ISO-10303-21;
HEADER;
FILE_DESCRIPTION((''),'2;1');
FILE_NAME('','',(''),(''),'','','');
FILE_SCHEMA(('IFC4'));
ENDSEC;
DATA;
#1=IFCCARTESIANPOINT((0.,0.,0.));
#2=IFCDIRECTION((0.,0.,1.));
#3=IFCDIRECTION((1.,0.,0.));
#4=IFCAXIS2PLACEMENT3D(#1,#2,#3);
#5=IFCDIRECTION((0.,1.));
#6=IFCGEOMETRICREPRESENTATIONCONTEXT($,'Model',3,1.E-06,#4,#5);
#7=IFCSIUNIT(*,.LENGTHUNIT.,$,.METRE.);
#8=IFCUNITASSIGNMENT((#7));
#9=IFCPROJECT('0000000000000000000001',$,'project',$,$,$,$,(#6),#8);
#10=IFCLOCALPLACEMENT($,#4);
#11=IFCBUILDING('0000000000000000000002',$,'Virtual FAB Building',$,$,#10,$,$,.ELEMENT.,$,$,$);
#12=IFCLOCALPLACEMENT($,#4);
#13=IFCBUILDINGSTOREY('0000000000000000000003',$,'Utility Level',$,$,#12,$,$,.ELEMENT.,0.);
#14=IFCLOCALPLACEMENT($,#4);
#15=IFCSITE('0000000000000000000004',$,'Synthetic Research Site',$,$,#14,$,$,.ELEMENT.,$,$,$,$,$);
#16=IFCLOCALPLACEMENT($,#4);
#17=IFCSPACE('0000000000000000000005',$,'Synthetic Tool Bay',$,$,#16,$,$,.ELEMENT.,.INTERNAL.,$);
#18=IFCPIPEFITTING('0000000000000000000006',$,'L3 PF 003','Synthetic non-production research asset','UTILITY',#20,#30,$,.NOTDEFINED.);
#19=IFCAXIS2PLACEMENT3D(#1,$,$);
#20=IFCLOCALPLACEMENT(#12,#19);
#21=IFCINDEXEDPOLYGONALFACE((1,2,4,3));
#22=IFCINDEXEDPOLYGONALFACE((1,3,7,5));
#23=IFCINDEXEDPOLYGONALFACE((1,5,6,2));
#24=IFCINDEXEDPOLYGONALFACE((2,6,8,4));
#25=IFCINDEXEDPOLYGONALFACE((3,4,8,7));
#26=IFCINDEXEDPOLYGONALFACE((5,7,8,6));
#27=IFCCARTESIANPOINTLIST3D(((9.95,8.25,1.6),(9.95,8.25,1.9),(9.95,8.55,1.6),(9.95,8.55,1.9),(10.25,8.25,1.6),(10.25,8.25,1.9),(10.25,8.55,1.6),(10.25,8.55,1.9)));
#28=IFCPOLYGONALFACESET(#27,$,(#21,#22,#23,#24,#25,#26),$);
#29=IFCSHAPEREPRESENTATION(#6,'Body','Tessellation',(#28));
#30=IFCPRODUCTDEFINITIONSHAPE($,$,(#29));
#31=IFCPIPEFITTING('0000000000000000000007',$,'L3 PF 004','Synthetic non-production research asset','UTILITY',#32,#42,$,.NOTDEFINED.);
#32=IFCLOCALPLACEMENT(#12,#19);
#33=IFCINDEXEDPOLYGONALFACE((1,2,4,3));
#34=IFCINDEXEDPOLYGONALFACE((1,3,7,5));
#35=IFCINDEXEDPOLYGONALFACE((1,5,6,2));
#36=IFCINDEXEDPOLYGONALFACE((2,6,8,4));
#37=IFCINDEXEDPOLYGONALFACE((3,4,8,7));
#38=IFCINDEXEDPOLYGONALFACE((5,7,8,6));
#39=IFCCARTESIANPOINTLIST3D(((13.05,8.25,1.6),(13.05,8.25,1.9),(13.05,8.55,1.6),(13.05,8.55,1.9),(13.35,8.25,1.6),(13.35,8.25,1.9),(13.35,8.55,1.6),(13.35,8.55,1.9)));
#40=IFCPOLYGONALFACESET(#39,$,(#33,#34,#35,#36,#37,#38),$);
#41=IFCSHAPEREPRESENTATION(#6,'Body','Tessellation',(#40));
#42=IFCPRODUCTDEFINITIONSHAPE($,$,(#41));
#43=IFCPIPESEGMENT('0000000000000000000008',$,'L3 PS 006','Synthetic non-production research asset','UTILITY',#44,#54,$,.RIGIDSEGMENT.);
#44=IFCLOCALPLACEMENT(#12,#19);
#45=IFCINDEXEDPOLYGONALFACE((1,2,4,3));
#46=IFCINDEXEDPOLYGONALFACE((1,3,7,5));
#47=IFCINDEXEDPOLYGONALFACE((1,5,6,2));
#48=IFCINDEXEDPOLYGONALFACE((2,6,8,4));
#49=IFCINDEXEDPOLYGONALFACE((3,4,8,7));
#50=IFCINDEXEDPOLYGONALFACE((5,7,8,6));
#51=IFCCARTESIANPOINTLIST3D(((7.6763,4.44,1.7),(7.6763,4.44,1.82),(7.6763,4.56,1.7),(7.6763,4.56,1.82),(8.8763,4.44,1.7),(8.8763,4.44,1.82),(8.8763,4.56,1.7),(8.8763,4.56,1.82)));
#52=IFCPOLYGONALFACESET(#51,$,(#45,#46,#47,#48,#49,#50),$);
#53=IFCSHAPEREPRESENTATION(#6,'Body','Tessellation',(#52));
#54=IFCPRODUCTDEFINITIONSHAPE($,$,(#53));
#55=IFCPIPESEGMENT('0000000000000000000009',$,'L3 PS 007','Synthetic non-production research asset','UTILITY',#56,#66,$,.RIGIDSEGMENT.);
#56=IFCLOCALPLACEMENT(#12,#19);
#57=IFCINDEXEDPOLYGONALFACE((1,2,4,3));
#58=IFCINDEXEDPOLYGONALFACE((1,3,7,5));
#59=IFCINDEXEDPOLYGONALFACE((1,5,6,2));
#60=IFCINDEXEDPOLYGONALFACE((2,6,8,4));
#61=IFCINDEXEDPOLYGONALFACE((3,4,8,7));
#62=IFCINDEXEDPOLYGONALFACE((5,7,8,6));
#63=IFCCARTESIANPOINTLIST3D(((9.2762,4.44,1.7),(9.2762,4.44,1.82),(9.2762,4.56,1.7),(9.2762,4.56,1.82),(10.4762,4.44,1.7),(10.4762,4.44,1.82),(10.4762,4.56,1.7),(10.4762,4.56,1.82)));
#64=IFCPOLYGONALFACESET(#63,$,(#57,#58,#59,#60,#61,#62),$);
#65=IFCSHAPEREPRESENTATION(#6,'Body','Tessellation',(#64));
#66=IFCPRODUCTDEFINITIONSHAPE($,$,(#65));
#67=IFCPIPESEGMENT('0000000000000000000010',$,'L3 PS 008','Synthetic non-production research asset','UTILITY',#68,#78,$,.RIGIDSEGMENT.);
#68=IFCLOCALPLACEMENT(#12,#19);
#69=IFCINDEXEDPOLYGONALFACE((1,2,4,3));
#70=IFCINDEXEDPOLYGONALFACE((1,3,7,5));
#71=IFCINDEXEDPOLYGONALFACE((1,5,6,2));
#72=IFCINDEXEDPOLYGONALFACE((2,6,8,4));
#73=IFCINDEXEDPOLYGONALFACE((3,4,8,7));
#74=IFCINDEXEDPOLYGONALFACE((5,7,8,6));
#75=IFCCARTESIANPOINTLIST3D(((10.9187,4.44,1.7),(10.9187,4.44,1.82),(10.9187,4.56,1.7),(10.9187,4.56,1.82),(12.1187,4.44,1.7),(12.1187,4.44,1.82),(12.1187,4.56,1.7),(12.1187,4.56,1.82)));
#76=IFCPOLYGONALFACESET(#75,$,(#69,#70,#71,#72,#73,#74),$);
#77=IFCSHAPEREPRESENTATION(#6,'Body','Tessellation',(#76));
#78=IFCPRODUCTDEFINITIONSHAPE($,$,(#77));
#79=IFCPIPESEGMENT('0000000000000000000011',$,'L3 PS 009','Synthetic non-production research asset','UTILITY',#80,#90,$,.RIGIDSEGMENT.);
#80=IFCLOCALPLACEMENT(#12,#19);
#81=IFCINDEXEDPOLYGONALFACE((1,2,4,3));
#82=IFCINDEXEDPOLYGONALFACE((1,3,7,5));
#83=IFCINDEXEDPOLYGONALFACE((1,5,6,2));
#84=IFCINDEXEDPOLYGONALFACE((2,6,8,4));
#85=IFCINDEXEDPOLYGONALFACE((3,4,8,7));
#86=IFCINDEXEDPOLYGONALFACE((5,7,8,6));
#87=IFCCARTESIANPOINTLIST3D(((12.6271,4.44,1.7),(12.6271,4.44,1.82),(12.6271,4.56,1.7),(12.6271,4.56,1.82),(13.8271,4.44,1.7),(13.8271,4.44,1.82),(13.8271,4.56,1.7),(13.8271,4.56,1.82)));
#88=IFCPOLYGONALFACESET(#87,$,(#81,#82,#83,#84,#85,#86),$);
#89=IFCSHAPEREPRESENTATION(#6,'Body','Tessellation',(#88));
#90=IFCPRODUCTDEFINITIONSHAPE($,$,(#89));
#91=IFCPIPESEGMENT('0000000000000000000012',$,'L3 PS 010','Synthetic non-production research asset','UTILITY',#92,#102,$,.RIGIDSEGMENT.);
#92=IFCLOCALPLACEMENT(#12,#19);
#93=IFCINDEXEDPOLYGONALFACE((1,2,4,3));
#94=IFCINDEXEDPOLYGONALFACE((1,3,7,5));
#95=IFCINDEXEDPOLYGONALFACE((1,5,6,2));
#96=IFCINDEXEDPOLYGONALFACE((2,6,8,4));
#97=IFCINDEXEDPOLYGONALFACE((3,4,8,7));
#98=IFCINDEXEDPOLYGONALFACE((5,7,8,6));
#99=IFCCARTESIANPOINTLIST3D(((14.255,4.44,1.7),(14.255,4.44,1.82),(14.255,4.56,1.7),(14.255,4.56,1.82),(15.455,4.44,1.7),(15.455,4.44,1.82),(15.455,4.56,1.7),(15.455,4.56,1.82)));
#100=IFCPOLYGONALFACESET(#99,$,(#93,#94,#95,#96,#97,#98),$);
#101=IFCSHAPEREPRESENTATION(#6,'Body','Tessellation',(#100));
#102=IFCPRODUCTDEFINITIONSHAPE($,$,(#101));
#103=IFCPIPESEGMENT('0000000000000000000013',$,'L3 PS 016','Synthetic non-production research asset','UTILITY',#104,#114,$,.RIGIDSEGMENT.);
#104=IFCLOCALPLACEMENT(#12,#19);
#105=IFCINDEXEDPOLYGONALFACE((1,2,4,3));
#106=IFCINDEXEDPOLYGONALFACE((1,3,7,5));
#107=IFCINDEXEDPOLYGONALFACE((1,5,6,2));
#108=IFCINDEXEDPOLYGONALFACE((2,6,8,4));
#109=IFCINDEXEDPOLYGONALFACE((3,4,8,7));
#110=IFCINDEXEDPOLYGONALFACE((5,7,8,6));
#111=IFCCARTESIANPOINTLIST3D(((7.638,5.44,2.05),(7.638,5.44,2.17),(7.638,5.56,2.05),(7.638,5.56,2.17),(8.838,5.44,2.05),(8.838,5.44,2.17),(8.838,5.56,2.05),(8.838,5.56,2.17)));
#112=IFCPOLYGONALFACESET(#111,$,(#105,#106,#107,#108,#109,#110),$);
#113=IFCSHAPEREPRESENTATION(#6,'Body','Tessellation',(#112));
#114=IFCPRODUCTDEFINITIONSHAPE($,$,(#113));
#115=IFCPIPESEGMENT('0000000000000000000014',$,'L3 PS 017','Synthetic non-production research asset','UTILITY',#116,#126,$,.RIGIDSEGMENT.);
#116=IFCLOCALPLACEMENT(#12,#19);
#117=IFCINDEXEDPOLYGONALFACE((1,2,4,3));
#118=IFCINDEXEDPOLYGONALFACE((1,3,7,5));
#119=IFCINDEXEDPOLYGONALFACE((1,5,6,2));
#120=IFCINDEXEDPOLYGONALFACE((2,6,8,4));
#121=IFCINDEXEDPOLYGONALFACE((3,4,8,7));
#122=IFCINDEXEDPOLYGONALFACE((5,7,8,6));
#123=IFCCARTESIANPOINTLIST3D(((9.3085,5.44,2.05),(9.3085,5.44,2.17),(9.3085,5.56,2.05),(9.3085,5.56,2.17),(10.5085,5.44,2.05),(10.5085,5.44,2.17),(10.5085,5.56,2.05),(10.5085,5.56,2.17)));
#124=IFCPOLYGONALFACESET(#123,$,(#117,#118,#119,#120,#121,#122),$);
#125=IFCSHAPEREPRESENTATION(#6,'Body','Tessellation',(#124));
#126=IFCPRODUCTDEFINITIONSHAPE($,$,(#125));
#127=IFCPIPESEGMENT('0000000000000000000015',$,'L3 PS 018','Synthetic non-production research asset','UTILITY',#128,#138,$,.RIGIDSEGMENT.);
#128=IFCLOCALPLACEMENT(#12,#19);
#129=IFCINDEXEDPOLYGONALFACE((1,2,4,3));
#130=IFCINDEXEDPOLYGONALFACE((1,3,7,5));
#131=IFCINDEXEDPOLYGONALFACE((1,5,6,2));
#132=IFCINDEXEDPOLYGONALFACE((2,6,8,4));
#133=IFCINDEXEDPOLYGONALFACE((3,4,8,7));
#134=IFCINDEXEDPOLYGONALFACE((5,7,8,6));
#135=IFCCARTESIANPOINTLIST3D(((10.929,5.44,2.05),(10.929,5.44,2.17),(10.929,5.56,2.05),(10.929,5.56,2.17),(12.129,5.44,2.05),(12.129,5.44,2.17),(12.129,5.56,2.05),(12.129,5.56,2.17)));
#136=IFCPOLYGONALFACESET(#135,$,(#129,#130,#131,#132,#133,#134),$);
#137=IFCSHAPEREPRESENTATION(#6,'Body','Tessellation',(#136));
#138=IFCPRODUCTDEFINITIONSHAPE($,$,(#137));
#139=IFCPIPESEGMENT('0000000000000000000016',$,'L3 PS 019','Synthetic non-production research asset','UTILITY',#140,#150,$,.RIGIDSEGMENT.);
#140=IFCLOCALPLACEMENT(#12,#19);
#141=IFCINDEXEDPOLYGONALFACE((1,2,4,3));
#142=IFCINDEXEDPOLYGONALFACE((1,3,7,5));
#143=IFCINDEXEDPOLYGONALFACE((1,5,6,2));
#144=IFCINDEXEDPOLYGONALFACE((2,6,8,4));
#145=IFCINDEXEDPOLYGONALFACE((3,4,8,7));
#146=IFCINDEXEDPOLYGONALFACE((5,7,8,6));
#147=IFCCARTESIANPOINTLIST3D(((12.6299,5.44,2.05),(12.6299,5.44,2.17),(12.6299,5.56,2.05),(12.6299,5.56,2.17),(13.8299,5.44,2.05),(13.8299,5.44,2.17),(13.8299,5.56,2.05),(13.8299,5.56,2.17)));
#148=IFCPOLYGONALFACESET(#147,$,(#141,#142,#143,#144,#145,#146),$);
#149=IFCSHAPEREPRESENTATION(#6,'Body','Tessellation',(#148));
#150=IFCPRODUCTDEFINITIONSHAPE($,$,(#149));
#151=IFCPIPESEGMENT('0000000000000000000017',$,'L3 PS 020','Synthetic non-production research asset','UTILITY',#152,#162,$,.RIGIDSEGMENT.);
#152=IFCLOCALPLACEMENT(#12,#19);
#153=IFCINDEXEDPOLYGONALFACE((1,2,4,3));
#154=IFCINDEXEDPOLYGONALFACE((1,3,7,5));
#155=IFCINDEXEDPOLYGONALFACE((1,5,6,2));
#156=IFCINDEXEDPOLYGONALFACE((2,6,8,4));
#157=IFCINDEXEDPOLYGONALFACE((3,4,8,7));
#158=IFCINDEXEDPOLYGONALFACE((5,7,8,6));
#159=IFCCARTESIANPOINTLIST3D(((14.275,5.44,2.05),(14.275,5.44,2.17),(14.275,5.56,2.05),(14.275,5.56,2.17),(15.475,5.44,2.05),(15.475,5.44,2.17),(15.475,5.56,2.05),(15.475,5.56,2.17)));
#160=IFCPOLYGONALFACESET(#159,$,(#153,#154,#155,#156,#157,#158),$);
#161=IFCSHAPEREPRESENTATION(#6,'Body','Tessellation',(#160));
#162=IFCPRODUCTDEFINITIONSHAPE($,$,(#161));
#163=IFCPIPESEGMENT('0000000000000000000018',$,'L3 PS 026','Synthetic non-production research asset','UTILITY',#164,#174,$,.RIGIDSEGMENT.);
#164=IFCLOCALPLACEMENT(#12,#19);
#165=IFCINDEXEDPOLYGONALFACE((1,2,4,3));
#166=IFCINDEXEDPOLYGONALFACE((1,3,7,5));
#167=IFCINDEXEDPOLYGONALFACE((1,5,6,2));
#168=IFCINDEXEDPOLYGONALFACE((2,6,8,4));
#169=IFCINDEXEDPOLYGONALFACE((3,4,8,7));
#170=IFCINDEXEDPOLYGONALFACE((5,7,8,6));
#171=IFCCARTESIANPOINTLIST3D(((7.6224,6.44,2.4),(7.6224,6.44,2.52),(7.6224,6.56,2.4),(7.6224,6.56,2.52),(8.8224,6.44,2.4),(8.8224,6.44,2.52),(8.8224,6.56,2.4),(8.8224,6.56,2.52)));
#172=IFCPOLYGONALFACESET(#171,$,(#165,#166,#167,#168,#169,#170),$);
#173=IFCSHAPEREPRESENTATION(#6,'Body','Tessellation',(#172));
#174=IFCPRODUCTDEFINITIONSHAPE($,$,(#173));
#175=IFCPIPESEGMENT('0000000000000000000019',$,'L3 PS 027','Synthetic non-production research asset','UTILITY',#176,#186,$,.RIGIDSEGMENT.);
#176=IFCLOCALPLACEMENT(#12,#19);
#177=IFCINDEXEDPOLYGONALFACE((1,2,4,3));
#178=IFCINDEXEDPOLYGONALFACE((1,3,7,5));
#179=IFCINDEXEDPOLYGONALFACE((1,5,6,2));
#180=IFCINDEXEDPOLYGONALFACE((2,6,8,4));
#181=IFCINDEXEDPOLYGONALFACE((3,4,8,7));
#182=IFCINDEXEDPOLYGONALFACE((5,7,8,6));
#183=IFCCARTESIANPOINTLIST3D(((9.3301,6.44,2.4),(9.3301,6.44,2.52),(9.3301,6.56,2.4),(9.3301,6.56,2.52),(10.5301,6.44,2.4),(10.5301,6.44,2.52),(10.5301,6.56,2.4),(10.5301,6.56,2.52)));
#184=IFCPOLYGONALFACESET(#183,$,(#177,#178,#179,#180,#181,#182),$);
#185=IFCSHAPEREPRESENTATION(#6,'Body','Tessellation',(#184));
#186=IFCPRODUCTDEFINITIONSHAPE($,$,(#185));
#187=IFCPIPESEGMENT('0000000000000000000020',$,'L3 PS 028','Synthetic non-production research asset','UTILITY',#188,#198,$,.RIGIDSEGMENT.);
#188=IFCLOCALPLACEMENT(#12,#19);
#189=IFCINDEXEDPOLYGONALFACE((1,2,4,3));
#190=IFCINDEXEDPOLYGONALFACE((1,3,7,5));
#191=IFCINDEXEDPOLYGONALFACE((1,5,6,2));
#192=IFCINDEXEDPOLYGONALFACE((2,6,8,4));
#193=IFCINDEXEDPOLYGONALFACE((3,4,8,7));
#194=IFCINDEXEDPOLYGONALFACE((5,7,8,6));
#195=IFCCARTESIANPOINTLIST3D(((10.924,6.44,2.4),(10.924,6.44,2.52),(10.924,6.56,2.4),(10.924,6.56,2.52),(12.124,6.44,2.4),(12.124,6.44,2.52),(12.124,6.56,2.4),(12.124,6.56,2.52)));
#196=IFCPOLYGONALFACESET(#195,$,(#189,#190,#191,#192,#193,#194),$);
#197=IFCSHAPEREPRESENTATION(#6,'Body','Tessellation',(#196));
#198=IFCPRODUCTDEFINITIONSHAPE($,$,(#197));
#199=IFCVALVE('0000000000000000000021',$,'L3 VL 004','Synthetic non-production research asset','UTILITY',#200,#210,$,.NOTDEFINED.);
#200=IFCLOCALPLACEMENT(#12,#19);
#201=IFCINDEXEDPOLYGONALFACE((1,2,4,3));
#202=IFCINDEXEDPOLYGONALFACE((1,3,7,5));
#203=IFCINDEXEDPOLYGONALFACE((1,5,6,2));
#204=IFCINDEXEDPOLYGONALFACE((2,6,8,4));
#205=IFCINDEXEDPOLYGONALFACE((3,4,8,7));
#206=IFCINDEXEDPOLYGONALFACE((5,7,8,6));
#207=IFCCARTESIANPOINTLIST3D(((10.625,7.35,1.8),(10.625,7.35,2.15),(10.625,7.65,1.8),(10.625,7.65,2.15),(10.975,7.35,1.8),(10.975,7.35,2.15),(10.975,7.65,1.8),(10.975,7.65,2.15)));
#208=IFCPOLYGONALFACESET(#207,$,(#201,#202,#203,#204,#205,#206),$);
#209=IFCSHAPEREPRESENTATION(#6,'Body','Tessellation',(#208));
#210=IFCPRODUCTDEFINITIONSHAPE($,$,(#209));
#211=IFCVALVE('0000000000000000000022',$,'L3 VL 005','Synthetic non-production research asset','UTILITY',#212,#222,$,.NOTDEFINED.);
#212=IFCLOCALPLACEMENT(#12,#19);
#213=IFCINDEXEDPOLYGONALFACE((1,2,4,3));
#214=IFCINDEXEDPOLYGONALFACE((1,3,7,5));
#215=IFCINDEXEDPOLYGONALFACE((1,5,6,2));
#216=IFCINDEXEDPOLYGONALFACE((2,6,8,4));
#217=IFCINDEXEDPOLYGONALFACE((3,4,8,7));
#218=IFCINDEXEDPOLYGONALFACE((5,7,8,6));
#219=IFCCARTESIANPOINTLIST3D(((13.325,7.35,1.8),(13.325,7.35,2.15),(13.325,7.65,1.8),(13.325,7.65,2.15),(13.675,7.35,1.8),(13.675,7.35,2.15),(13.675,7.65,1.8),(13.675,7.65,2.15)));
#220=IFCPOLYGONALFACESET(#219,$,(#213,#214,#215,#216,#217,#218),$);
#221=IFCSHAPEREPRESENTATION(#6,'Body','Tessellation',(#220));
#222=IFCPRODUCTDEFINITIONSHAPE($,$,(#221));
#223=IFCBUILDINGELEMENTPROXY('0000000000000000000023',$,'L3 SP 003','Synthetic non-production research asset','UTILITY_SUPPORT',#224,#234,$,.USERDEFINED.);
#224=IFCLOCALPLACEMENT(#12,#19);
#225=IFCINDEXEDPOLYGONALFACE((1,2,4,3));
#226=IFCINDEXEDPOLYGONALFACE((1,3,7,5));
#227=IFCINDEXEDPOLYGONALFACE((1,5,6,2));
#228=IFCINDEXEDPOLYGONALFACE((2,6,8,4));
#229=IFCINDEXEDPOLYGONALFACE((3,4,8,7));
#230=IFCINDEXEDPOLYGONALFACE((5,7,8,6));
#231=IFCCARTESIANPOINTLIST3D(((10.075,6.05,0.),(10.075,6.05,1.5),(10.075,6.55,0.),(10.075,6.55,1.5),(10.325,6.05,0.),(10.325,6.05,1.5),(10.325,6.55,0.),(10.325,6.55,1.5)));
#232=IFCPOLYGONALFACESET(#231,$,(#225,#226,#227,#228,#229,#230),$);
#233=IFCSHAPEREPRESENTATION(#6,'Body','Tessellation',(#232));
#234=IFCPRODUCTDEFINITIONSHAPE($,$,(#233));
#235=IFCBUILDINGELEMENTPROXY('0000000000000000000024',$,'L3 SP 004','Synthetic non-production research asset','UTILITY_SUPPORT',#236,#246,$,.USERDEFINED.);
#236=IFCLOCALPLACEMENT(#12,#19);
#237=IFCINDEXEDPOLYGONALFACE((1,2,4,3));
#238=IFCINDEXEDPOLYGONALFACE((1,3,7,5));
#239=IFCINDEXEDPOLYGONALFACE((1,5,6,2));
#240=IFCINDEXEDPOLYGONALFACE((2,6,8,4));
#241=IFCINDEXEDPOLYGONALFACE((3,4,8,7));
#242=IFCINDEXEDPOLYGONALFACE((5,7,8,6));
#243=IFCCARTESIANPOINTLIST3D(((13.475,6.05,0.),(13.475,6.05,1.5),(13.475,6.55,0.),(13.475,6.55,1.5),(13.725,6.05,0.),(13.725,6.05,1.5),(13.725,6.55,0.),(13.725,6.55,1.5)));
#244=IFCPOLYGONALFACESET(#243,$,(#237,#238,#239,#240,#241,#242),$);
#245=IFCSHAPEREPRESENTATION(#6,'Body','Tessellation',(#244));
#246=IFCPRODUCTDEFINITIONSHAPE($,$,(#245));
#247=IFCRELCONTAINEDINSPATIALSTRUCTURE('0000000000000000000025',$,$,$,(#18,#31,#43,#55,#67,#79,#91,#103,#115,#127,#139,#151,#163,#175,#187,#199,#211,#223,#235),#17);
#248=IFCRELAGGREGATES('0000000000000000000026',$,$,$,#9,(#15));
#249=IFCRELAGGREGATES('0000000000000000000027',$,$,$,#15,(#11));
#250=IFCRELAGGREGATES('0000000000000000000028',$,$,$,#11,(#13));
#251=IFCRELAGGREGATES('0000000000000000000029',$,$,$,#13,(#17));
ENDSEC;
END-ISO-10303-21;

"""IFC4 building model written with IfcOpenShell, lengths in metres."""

from ifc_helpers import new_model, si_unit, direction, frame, origin_with_axes, origin_2d_with_axis, place, context, project, spatial, rectangle, extrude, element, save


model = new_model("IFC4")

# Units and contexts
model_context = context("Model", 3, precision=1e-06, world=origin_with_axes(), true_north=direction((0.0, 1.0)))
ifc_project = project(units=[si_unit("LENGTHUNIT", "METRE")], contexts=[model_context])

# Site, building, storey, space
site_placement = place(None, origin_with_axes())
site = spatial("IfcSite", under=ifc_project, at=site_placement, Name="Synthetic Research Site", CompositionType="ELEMENT")
building_placement = place(None, origin_with_axes())
building = spatial("IfcBuilding", under=site, at=building_placement, Name="Virtual FAB Building", CompositionType="ELEMENT")
storey_placement = place(None, origin_with_axes())
storey = spatial("IfcBuildingStorey", under=building, at=storey_placement, Name="Utility Level", CompositionType="ELEMENT", Elevation=0.0)
space_placement = place(None, origin_with_axes())
space = spatial("IfcSpace", under=storey, at=space_placement, Name="Synthetic Tool Bay", CompositionType="ELEMENT", PredefinedType="INTERNAL")

# Pipe fittings
for number, where, z_axis, x_axis, name in (
    (1, (10.1, 8.4, 1.6), (0.0, 0.0, 1.0), (1.0, 0.0, 0.0), "L3 PF 003"),
    (2, (13.2, 8.4, 1.6), (0.0, 0.0, 1.0), (1.0, 0.0, 0.0), "L3 PF 004"),
):
    element("IfcPipeFitting", number, at=place(None, frame(where, z_axis=z_axis, x_axis=x_axis)), inside=space, Name=name, Description="Synthetic non-production research asset", ObjectType="UTILITY", PredefinedType="NOTDEFINED", context=model_context, shape_type="SweptSolid", body=[
        extrude(rectangle(XDim=0.3, YDim=0.3, at=origin_2d_with_axis()), origin_with_axes(), (0.0, 0.0, 1.0), 0.3),
    ])

# Pipe segments
for number, where, z_axis, x_axis, name in (
    (3, (8.2763, 4.5, 1.7), (0.0, 0.0, 1.0), (1.0, 0.0, 0.0), "L3 PS 006"),
    (4, (9.8762, 4.5, 1.7), (0.0, 0.0, 1.0), (1.0, 0.0, 0.0), "L3 PS 007"),
    (5, (11.5187, 4.5, 1.7), (0.0, 0.0, 1.0), (1.0, 0.0, 0.0), "L3 PS 008"),
    (6, (13.2271, 4.5, 1.7), (0.0, 0.0, 1.0), (1.0, 0.0, 0.0), "L3 PS 009"),
    (7, (14.855, 4.5, 1.7), (0.0, 0.0, 1.0), (1.0, 0.0, 0.0), "L3 PS 010"),
    (8, (8.238, 5.5, 2.05), (0.0, 0.0, 1.0), (1.0, 0.0, 0.0), "L3 PS 016"),
    (9, (9.9085, 5.5, 2.05), (0.0, 0.0, 1.0), (1.0, 0.0, 0.0), "L3 PS 017"),
    (10, (11.529, 5.5, 2.05), (0.0, 0.0, 1.0), (1.0, 0.0, 0.0), "L3 PS 018"),
    (11, (13.2299, 5.5, 2.05), (0.0, 0.0, 1.0), (1.0, 0.0, 0.0), "L3 PS 019"),
    (12, (14.875, 5.5, 2.05), (0.0, 0.0, 1.0), (1.0, 0.0, 0.0), "L3 PS 020"),
    (13, (8.2224, 6.5, 2.4), (0.0, 0.0, 1.0), (1.0, 0.0, 0.0), "L3 PS 026"),
    (14, (9.9301, 6.5, 2.4), (0.0, 0.0, 1.0), (1.0, 0.0, 0.0), "L3 PS 027"),
    (15, (11.524, 6.5, 2.4), (0.0, 0.0, 1.0), (1.0, 0.0, 0.0), "L3 PS 028"),
):
    element("IfcPipeSegment", number, at=place(None, frame(where, z_axis=z_axis, x_axis=x_axis)), inside=space, Name=name, Description="Synthetic non-production research asset", ObjectType="UTILITY", PredefinedType="RIGIDSEGMENT", context=model_context, shape_type="SweptSolid", body=[
        extrude(rectangle(XDim=1.2, YDim=0.12, at=origin_2d_with_axis()), origin_with_axes(), (0.0, 0.0, 1.0), 0.12),
    ])

# Valves
for number, where, z_axis, x_axis, name in (
    (16, (10.8, 7.5, 1.8), (0.0, 0.0, 1.0), (1.0, 0.0, 0.0), "L3 VL 004"),
    (17, (13.5, 7.5, 1.8), (0.0, 0.0, 1.0), (1.0, 0.0, 0.0), "L3 VL 005"),
):
    element("IfcValve", number, at=place(None, frame(where, z_axis=z_axis, x_axis=x_axis)), inside=space, Name=name, Description="Synthetic non-production research asset", ObjectType="UTILITY", PredefinedType="NOTDEFINED", context=model_context, shape_type="SweptSolid", body=[
        extrude(rectangle(XDim=0.35, YDim=0.3, at=origin_2d_with_axis()), origin_with_axes(), (0.0, 0.0, 1.0), 0.35),
    ])

# Building element proxies
for number, where, z_axis, x_axis, name in (
    (18, (10.2, 6.3, 0.0), (0.0, 0.0, 1.0), (1.0, 0.0, 0.0), "L3 SP 003"),
    (19, (13.6, 6.3, 0.0), (0.0, 0.0, 1.0), (1.0, 0.0, 0.0), "L3 SP 004"),
):
    element("IfcBuildingElementProxy", number, at=place(None, frame(where, z_axis=z_axis, x_axis=x_axis)), inside=space, Name=name, Description="Synthetic non-production research asset", ObjectType="UTILITY_SUPPORT", PredefinedType="USERDEFINED", context=model_context, shape_type="SweptSolid", body=[
        extrude(rectangle(XDim=0.25, YDim=0.5, at=origin_2d_with_axis()), origin_with_axes(), (0.0, 0.0, 1.0), 1.5),
    ])

save(model, "model.ifc")
